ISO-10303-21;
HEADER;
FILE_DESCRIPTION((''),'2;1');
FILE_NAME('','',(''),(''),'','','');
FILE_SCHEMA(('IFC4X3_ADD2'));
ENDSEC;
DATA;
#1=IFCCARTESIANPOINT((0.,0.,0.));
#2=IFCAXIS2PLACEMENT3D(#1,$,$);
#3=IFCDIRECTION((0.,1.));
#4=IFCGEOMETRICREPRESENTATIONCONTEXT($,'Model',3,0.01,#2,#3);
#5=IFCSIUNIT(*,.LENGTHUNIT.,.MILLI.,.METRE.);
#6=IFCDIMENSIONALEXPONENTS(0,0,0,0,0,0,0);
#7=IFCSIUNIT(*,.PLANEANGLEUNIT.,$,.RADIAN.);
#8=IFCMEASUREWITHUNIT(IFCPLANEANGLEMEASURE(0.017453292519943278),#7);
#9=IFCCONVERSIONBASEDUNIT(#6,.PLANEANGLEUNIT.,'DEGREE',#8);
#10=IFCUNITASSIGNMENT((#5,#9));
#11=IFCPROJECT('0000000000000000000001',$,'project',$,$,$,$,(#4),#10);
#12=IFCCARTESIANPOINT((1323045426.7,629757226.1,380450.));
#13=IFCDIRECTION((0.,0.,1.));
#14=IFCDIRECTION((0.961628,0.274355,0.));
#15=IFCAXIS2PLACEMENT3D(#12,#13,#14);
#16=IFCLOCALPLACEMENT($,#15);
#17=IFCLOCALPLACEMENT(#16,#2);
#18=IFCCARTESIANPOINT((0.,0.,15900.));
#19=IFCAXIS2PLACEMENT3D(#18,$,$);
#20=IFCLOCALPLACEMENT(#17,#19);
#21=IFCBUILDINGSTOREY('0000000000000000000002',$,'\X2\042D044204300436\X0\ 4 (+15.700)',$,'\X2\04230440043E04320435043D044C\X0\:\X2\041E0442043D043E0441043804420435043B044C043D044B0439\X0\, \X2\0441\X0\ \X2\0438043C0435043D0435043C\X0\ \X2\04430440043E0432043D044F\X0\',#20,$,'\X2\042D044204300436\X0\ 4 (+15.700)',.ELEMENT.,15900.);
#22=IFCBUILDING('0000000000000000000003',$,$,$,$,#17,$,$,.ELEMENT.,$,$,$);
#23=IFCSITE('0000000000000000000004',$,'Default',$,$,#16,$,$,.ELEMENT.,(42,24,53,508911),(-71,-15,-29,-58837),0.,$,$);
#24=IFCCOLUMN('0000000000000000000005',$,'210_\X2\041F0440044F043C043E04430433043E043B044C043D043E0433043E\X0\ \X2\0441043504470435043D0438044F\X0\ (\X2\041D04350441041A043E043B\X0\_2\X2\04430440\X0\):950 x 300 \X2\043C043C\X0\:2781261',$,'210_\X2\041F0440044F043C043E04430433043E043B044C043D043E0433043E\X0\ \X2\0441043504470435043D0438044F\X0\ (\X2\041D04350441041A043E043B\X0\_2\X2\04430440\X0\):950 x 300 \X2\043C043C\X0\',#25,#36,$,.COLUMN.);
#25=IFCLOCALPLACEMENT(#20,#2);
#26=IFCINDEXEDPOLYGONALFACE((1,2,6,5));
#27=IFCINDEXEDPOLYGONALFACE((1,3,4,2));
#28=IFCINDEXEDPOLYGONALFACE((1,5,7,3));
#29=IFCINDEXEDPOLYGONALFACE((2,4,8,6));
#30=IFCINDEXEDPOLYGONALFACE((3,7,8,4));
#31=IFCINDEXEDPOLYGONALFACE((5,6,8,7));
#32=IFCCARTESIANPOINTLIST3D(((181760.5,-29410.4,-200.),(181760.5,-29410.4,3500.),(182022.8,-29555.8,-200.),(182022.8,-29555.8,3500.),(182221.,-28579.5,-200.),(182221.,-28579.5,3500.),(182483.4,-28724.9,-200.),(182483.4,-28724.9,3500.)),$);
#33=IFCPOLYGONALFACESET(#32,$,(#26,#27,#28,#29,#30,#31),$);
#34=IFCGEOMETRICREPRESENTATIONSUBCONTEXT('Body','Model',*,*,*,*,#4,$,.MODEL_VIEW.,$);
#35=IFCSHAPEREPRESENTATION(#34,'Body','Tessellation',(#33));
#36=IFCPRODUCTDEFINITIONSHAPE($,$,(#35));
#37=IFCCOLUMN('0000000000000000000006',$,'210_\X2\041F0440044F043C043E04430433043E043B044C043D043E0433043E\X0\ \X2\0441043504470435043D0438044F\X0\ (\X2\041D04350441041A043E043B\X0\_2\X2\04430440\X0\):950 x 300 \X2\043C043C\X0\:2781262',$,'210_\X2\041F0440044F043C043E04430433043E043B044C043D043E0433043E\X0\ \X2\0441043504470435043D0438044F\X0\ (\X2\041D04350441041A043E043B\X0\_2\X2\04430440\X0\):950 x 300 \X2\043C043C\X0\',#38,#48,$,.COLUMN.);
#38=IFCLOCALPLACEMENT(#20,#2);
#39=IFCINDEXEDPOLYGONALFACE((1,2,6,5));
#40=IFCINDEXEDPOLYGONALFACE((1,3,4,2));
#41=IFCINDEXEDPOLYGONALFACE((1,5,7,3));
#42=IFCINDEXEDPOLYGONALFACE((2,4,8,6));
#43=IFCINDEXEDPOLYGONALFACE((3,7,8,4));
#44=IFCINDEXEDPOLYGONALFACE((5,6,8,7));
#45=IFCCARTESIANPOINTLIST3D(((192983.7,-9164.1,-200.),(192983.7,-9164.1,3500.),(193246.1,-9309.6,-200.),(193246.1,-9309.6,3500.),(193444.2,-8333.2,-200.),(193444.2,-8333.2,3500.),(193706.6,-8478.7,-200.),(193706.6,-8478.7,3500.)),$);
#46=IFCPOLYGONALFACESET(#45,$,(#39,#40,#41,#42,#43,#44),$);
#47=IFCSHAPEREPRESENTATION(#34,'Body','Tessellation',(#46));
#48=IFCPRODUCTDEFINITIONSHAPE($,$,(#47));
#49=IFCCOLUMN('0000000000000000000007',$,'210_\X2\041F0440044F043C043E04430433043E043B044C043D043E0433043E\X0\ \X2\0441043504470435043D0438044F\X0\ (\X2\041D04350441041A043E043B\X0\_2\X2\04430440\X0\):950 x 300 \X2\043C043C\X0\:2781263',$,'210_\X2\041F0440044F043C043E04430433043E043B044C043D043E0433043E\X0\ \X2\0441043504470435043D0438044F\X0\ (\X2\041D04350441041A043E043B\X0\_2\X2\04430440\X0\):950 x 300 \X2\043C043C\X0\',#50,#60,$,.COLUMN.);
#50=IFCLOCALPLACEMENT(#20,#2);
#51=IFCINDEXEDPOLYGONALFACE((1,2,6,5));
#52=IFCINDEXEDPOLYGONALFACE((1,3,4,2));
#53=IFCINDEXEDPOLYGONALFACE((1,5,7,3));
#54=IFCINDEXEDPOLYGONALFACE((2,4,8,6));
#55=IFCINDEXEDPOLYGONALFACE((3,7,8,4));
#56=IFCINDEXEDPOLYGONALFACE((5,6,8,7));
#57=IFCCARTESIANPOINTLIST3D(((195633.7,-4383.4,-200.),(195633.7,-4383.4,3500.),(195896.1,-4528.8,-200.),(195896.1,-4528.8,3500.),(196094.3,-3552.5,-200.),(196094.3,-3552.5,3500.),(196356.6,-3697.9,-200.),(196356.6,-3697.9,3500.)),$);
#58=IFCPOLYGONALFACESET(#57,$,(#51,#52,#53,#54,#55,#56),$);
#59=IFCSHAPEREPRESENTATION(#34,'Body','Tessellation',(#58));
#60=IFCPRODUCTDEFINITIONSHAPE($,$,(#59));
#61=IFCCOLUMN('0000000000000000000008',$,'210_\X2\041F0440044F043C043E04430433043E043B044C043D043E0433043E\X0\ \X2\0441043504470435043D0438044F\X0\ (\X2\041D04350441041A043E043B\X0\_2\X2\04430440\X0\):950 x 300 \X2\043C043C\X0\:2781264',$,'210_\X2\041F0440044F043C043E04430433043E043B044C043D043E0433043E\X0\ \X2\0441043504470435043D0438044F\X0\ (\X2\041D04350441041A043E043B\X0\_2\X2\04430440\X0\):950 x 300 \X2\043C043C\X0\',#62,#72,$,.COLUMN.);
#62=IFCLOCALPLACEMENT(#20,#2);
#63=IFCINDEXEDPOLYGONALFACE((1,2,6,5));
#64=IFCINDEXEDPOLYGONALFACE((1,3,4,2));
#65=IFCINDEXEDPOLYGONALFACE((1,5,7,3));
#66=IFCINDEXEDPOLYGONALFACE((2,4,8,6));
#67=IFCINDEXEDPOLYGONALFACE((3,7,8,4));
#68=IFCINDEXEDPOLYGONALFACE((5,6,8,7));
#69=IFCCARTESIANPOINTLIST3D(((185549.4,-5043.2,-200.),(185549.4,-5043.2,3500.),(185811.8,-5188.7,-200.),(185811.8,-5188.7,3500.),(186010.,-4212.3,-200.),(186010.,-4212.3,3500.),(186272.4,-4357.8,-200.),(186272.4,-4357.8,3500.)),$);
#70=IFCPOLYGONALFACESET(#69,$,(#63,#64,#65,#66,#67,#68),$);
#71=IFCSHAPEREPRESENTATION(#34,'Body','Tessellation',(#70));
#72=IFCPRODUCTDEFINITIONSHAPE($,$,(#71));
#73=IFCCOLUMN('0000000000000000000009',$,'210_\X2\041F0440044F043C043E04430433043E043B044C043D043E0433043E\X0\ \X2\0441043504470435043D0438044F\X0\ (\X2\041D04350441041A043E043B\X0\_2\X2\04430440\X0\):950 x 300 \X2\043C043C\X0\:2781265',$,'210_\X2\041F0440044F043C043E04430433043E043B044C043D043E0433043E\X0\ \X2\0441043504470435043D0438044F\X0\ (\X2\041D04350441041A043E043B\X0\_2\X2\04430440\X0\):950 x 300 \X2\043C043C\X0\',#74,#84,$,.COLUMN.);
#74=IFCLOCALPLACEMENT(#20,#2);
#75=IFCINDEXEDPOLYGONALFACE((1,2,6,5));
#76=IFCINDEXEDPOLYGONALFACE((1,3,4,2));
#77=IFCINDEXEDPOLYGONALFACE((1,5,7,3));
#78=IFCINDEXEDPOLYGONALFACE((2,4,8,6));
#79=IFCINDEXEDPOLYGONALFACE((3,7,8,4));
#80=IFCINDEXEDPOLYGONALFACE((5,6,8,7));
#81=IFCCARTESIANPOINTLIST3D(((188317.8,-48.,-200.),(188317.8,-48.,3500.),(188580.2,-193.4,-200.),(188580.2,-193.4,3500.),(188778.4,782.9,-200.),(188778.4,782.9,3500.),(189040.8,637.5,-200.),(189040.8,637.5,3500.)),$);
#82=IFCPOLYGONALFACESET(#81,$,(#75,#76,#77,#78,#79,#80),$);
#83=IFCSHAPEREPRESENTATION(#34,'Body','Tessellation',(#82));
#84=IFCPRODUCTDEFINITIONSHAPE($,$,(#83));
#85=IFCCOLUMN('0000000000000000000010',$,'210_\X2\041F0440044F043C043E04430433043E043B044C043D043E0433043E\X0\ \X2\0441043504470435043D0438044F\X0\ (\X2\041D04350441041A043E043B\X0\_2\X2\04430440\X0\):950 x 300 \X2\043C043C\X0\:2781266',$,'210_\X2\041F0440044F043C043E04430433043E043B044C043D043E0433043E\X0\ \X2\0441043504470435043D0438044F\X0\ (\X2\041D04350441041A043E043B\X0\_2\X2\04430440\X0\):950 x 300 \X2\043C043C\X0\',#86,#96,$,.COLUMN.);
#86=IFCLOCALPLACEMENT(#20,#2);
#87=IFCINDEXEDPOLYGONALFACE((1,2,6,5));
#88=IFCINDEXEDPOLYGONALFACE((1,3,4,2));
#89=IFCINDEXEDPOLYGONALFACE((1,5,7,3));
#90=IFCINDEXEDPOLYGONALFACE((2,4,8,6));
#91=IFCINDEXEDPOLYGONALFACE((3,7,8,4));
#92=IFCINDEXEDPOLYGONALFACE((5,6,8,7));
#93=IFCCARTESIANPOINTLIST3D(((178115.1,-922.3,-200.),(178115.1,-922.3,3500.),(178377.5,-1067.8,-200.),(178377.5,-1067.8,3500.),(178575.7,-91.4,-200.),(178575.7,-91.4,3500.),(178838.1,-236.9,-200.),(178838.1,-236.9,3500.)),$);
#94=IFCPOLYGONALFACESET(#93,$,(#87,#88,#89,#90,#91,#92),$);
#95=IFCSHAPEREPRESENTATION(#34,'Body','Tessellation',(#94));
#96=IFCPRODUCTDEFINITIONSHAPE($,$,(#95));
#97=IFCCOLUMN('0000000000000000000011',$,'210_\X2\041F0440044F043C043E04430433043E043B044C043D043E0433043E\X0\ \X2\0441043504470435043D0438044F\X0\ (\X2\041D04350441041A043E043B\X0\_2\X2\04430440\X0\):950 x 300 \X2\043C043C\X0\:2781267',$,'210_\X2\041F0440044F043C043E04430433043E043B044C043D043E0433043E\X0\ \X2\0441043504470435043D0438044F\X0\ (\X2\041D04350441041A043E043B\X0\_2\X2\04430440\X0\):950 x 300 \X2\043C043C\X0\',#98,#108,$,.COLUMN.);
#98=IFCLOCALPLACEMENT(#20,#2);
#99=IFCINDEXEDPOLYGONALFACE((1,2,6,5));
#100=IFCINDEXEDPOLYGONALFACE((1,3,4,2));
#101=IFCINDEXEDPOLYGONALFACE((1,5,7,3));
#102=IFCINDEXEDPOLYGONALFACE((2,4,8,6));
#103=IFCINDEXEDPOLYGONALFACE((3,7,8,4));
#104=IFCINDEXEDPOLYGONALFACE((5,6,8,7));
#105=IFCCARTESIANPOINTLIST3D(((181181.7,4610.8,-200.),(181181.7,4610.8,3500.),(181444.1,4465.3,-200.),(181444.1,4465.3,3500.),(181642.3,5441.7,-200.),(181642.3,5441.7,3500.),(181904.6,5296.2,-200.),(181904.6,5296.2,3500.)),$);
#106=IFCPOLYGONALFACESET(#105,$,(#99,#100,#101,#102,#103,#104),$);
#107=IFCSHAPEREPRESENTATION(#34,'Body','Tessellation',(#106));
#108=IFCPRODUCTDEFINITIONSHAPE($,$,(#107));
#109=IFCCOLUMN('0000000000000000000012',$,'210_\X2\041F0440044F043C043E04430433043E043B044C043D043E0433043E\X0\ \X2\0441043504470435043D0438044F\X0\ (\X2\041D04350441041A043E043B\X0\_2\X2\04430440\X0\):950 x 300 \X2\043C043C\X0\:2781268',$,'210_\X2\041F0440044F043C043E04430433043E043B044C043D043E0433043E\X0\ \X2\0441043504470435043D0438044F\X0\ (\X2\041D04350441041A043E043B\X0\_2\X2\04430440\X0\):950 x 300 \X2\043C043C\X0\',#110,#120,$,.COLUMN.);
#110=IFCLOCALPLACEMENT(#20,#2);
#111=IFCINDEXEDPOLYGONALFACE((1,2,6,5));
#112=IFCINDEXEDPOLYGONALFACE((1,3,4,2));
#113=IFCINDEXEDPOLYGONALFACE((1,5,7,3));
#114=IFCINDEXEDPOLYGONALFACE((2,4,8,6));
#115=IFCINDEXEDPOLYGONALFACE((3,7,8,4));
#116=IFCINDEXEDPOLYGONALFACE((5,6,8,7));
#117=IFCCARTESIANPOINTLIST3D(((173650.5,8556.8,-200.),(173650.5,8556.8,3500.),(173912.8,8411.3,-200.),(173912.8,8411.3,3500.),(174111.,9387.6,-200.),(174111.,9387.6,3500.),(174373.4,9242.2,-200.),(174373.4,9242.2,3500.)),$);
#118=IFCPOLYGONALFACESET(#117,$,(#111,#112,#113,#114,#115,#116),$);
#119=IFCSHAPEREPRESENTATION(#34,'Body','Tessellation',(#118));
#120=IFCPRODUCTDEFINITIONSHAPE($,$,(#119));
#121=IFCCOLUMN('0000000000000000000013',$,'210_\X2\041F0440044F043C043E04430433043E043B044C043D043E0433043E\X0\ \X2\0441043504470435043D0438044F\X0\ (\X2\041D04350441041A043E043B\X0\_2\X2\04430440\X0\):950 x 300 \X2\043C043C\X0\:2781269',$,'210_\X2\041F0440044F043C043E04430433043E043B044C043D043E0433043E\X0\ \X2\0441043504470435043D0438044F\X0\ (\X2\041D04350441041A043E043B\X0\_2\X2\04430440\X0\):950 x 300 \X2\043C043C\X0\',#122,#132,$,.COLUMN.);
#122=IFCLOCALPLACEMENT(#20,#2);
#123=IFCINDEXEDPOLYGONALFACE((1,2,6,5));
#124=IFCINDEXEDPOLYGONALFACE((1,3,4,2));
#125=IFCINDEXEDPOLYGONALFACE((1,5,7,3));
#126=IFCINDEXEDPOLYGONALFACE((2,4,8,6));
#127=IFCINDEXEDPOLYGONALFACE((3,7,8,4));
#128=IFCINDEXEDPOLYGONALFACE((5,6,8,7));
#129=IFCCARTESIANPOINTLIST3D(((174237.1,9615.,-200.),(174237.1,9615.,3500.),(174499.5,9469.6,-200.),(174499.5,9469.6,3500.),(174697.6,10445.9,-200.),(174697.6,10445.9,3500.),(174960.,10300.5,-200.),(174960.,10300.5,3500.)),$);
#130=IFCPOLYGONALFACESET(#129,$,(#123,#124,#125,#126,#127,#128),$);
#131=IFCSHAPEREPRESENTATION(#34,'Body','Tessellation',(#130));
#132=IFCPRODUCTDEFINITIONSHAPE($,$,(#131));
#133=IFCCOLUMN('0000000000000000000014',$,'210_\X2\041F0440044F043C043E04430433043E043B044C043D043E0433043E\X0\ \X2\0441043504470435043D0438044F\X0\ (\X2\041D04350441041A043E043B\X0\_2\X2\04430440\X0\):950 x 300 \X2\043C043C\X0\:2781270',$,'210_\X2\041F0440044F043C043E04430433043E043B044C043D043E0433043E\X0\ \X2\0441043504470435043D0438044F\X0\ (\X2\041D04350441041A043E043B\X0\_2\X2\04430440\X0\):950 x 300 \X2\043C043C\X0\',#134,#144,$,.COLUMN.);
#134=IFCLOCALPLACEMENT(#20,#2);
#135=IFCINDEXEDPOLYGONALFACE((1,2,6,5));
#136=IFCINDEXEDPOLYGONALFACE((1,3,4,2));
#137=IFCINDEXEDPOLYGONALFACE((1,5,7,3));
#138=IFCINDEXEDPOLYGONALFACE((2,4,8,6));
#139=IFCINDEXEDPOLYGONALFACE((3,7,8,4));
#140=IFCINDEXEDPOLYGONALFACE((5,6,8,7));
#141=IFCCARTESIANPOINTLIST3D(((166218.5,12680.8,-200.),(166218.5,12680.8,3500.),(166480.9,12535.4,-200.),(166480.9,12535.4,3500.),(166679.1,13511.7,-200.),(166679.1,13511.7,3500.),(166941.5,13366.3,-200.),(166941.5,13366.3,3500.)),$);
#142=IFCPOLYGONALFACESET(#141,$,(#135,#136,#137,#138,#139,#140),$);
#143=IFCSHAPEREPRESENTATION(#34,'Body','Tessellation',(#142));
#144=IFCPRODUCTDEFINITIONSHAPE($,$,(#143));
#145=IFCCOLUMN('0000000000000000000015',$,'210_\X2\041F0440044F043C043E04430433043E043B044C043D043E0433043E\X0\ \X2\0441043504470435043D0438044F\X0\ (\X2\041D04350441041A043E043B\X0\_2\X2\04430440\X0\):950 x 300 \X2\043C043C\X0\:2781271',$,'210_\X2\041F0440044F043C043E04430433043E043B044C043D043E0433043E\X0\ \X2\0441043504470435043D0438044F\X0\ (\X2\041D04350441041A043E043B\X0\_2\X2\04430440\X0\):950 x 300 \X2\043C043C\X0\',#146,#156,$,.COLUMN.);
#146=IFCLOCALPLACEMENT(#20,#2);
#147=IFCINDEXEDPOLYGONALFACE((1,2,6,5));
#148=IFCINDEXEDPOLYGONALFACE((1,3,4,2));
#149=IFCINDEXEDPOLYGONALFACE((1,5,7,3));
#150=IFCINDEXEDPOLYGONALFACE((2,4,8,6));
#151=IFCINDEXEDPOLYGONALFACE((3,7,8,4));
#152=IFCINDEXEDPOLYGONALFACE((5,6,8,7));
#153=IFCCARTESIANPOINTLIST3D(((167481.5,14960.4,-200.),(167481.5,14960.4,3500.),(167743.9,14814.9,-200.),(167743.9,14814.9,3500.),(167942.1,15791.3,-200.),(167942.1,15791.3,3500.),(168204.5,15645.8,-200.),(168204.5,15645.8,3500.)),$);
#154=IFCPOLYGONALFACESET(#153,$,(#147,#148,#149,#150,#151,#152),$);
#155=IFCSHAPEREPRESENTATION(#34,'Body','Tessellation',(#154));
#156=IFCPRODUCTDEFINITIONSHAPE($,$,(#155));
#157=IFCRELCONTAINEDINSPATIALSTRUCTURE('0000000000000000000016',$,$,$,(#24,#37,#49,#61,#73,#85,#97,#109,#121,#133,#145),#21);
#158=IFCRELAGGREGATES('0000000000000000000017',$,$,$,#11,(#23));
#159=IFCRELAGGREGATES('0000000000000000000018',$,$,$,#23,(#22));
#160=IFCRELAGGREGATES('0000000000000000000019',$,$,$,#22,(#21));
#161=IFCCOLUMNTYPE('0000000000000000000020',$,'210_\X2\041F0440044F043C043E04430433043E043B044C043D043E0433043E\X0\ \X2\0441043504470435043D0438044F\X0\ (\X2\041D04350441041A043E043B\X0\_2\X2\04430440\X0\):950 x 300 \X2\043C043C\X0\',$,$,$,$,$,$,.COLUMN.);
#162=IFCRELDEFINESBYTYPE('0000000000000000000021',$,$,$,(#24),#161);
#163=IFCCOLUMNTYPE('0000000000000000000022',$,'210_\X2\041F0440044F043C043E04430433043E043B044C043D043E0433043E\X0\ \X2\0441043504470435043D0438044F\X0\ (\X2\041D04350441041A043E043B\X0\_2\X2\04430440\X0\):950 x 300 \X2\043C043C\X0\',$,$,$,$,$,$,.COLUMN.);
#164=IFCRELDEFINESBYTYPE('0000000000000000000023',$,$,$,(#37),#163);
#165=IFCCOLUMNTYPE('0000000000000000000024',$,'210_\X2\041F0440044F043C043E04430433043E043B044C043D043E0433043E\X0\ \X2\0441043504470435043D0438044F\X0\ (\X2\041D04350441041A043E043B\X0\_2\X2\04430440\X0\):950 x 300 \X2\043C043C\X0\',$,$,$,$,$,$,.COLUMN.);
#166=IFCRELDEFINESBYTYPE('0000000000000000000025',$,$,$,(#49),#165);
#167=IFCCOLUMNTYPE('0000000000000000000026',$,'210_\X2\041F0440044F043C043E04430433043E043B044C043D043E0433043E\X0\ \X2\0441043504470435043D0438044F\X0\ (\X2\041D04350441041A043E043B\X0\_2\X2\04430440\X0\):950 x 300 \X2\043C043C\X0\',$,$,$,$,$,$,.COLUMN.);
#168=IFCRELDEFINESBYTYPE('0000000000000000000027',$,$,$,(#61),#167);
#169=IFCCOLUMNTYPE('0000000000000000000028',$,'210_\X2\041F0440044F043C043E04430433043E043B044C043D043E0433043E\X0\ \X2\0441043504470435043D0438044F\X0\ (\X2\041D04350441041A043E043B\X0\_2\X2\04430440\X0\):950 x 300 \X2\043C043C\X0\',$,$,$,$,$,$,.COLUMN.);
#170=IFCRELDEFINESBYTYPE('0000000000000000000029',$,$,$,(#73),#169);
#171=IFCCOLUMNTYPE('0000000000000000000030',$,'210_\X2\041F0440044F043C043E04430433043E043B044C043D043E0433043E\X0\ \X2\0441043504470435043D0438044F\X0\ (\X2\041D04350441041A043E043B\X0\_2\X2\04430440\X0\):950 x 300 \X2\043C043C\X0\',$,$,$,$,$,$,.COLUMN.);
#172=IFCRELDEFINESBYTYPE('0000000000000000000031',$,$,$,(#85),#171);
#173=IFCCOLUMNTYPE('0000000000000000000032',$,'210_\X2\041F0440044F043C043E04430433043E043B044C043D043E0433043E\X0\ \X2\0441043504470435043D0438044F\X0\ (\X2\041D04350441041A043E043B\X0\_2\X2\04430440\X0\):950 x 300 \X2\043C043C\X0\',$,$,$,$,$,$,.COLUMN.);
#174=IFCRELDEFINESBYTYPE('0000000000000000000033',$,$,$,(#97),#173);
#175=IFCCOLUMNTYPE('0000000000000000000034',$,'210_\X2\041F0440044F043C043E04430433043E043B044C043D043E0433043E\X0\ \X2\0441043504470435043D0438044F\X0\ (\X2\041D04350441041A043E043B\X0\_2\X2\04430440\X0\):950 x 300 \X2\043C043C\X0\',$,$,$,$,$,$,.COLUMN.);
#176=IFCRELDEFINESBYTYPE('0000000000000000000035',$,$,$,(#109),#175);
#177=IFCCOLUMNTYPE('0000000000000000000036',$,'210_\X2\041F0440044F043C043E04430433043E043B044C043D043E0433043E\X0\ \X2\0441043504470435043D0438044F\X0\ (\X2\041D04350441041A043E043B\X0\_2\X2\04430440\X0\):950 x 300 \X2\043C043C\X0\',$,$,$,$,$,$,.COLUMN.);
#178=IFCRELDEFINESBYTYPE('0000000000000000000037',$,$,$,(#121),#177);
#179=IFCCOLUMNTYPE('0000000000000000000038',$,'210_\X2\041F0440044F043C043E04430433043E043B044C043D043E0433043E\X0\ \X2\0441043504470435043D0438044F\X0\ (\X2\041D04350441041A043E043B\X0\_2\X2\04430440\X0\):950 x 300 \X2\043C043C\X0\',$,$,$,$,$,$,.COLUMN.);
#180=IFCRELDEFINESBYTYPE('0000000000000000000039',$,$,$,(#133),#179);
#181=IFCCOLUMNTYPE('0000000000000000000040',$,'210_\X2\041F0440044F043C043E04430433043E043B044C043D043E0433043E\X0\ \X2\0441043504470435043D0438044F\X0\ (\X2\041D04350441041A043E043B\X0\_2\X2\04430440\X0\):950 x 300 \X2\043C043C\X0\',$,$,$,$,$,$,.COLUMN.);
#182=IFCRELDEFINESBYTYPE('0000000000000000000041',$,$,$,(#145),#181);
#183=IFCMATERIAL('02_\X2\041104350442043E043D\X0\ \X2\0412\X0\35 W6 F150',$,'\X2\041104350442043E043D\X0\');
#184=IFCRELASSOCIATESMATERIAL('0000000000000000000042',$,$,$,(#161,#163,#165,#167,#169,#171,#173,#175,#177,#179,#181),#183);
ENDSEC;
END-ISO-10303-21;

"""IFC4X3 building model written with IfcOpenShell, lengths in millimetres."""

from ifc_helpers import new_model, entity, si_unit, converted_unit, direction, frame, frame_2d, origin, origin_2d_with_axis, place, context, subcontext, project, spatial, rectangle, extrude, source, transform, mapped, material, material_profile, profile_set, type_object, type_shapes, element, save


model = new_model("IFC4X3")

# Units and contexts
model_context = context("Model", 3, precision=0.01, world=origin(), true_north=direction((0.0, 1.0)))
body_context = subcontext(model_context, "Body", "Model", "MODEL_VIEW")
ifc_project = project(units=[si_unit("LENGTHUNIT", "METRE", prefix="MILLI"), converted_unit("PLANEANGLEUNIT", "DEGREE", entity("IfcPlaneAngleMeasure", 0.017453292519943278), si_unit("PLANEANGLEUNIT", "RADIAN"), dimensions=[0, 0, 0, 0, 0, 0, 0])], contexts=[model_context])

# Site, building, storey
site_placement = place(None, frame((1323045426.7, 629757226.1, 380450.0), z_axis=(0.0, 0.0, 1.0), x_axis=(0.961628, 0.274355, 0.0)))
site = spatial("IfcSite", under=ifc_project, at=site_placement, Name="Default", CompositionType="ELEMENT", RefLatitude=(42, 24, 53, 508911), RefLongitude=(-71, -15, -29, -58837), RefElevation=0.0)
building_placement = place(site_placement, origin())
building = spatial("IfcBuilding", under=site, at=building_placement, CompositionType="ELEMENT")
storey_placement = place(building_placement, frame((0.0, 0.0, 15900.0)))
storey = spatial("IfcBuildingStorey", under=building, at=storey_placement, Name="Этаж 4 (+15.700)", ObjectType="Уровень:Относительный, с именем уровня", LongName="Этаж 4 (+15.700)", CompositionType="ELEMENT", Elevation=15900.0)

# Columns
ifc_material = material(Name="02_Бетон В35 W6 F150", Category="Бетон")
ifc_material_profile_1 = material_profile(ifc_material, rectangle(XDim=300.0, YDim=950.0, at=frame_2d((0.0, 0.0), x_axis=(1.0, 0.0))), Name="950 x 300 мм")
ifc_profile_set_1 = profile_set([ifc_material_profile_1], Name="950 x 300 мм")
column_type_1 = type_object("IfcColumnType", Name="210_Прямоугольного сечения (НесКол_2ур):950 x 300 мм", PredefinedType="COLUMN", material=ifc_profile_set_1)
shared_shape_1 = source(origin(), body_context, "Body", "SweptSolid", [
    extrude(rectangle(XDim=300.0, YDim=950.0, at=origin_2d_with_axis()), frame((182121.9, -29067.7, 15700.0), z_axis=(0.0, 0.0, 1.0), x_axis=(-0.87462, 0.48481, 0.0)), (0.0, 0.0, 1.0), 3700.0),
])
type_shapes(column_type_1, [shared_shape_1])
column_1_placement = place(storey_placement, frame((0.0, 0.0, -15900.0)))
element("IfcColumn", 1, at=column_1_placement, inside=storey, type_object=column_type_1, Name="210_Прямоугольного сечения (НесКол_2ур):950 x 300 мм:2781261", ObjectType="210_Прямоугольного сечения (НесКол_2ур):950 x 300 мм", PredefinedType="COLUMN", context=body_context, shape_type="MappedRepresentation", body=[
    mapped(shared_shape_1, transform((0.0, 0.0, 0.0), scale=1.0)),
])
column_type_2 = type_object("IfcColumnType", Name="210_Прямоугольного сечения (НесКол_2ур):950 x 300 мм", PredefinedType="COLUMN", material=ifc_profile_set_1)
shared_shape_2 = source(origin(), body_context, "Body", "SweptSolid", [
    extrude(rectangle(XDim=300.0, YDim=950.0, at=frame_2d((0.0, 0.0), x_axis=(1.0, 0.0))), frame((193345.2, -8821.4, 15700.0), z_axis=(0.0, 0.0, 1.0), x_axis=(-0.87462, 0.48481, 0.0)), (0.0, 0.0, 1.0), 3700.0),
])
type_shapes(column_type_2, [shared_shape_2])
column_2_placement = place(storey_placement, frame((0.0, 0.0, -15900.0)))
element("IfcColumn", 2, at=column_2_placement, inside=storey, type_object=column_type_2, Name="210_Прямоугольного сечения (НесКол_2ур):950 x 300 мм:2781262", ObjectType="210_Прямоугольного сечения (НесКол_2ур):950 x 300 мм", PredefinedType="COLUMN", context=body_context, shape_type="MappedRepresentation", body=[
    mapped(shared_shape_2, transform((0.0, 0.0, 0.0), scale=1.0)),
])
column_type_3 = type_object("IfcColumnType", Name="210_Прямоугольного сечения (НесКол_2ур):950 x 300 мм", PredefinedType="COLUMN", material=ifc_profile_set_1)
shared_shape_3 = source(origin(), body_context, "Body", "SweptSolid", [
    extrude(rectangle(XDim=300.0, YDim=950.0, at=frame_2d((0.0, 0.0), x_axis=(1.0, 0.0))), frame((195995.2, -4040.7, 15700.0), z_axis=(0.0, 0.0, 1.0), x_axis=(-0.87462, 0.48481, 0.0)), (0.0, 0.0, 1.0), 3700.0),
])
type_shapes(column_type_3, [shared_shape_3])
column_3_placement = place(storey_placement, frame((0.0, 0.0, -15900.0)))
element("IfcColumn", 3, at=column_3_placement, inside=storey, type_object=column_type_3, Name="210_Прямоугольного сечения (НесКол_2ур):950 x 300 мм:2781263", ObjectType="210_Прямоугольного сечения (НесКол_2ур):950 x 300 мм", PredefinedType="COLUMN", context=body_context, shape_type="MappedRepresentation", body=[
    mapped(shared_shape_3, transform((0.0, 0.0, 0.0), scale=1.0)),
])
column_type_4 = type_object("IfcColumnType", Name="210_Прямоугольного сечения (НесКол_2ур):950 x 300 мм", PredefinedType="COLUMN", material=ifc_profile_set_1)
shared_shape_4 = source(origin(), body_context, "Body", "SweptSolid", [
    extrude(rectangle(XDim=300.0, YDim=950.0, at=frame_2d((0.0, 0.0), x_axis=(1.0, 0.0))), frame((185910.9, -4700.5, 15700.0), z_axis=(0.0, 0.0, 1.0), x_axis=(-0.87462, 0.48481, 0.0)), (0.0, 0.0, 1.0), 3700.0),
])
type_shapes(column_type_4, [shared_shape_4])
column_4_placement = place(storey_placement, frame((0.0, 0.0, -15900.0)))
element("IfcColumn", 4, at=column_4_placement, inside=storey, type_object=column_type_4, Name="210_Прямоугольного сечения (НесКол_2ур):950 x 300 мм:2781264", ObjectType="210_Прямоугольного сечения (НесКол_2ур):950 x 300 мм", PredefinedType="COLUMN", context=body_context, shape_type="MappedRepresentation", body=[
    mapped(shared_shape_4, transform((0.0, 0.0, 0.0), scale=1.0)),
])
column_type_5 = type_object("IfcColumnType", Name="210_Прямоугольного сечения (НесКол_2ур):950 x 300 мм", PredefinedType="COLUMN", material=ifc_profile_set_1)
shared_shape_5 = source(origin(), body_context, "Body", "SweptSolid", [
    extrude(rectangle(XDim=300.0, YDim=950.0, at=frame_2d((0.0, 0.0), x_axis=(1.0, 0.0))), frame((188679.3, 294.7, 15700.0), z_axis=(0.0, 0.0, 1.0), x_axis=(-0.87462, 0.48481, 0.0)), (0.0, 0.0, 1.0), 3700.0),
])
type_shapes(column_type_5, [shared_shape_5])
column_5_placement = place(storey_placement, frame((0.0, 0.0, -15900.0)))
element("IfcColumn", 5, at=column_5_placement, inside=storey, type_object=column_type_5, Name="210_Прямоугольного сечения (НесКол_2ур):950 x 300 мм:2781265", ObjectType="210_Прямоугольного сечения (НесКол_2ур):950 x 300 мм", PredefinedType="COLUMN", context=body_context, shape_type="MappedRepresentation", body=[
    mapped(shared_shape_5, transform((0.0, 0.0, 0.0), scale=1.0)),
])
column_type_6 = type_object("IfcColumnType", Name="210_Прямоугольного сечения (НесКол_2ур):950 x 300 мм", PredefinedType="COLUMN", material=ifc_profile_set_1)
shared_shape_6 = source(origin(), body_context, "Body", "SweptSolid", [
    extrude(rectangle(XDim=300.0, YDim=950.0, at=frame_2d((0.0, 0.0), x_axis=(1.0, 0.0))), frame((178476.6, -579.6, 15700.0), z_axis=(0.0, 0.0, 1.0), x_axis=(-0.87462, 0.48481, 0.0)), (0.0, 0.0, 1.0), 3700.0),
])
type_shapes(column_type_6, [shared_shape_6])
column_6_placement = place(storey_placement, frame((0.0, 0.0, -15900.0)))
element("IfcColumn", 6, at=column_6_placement, inside=storey, type_object=column_type_6, Name="210_Прямоугольного сечения (НесКол_2ур):950 x 300 мм:2781266", ObjectType="210_Прямоугольного сечения (НесКол_2ур):950 x 300 мм", PredefinedType="COLUMN", context=body_context, shape_type="MappedRepresentation", body=[
    mapped(shared_shape_6, transform((0.0, 0.0, 0.0), scale=1.0)),
])
column_type_7 = type_object("IfcColumnType", Name="210_Прямоугольного сечения (НесКол_2ур):950 x 300 мм", PredefinedType="COLUMN", material=ifc_profile_set_1)
shared_shape_7 = source(origin(), body_context, "Body", "SweptSolid", [
    extrude(rectangle(XDim=300.0, YDim=950.0, at=frame_2d((0.0, 0.0), x_axis=(1.0, 0.0))), frame((181543.2, 4953.5, 15700.0), z_axis=(0.0, 0.0, 1.0), x_axis=(-0.87462, 0.48481, 0.0)), (0.0, 0.0, 1.0), 3700.0),
])
type_shapes(column_type_7, [shared_shape_7])
column_7_placement = place(storey_placement, frame((0.0, 0.0, -15900.0)))
element("IfcColumn", 7, at=column_7_placement, inside=storey, type_object=column_type_7, Name="210_Прямоугольного сечения (НесКол_2ур):950 x 300 мм:2781267", ObjectType="210_Прямоугольного сечения (НесКол_2ур):950 x 300 мм", PredefinedType="COLUMN", context=body_context, shape_type="MappedRepresentation", body=[
    mapped(shared_shape_7, transform((0.0, 0.0, 0.0), scale=1.0)),
])
column_type_8 = type_object("IfcColumnType", Name="210_Прямоугольного сечения (НесКол_2ур):950 x 300 мм", PredefinedType="COLUMN", material=ifc_profile_set_1)
shared_shape_8 = source(origin(), body_context, "Body", "SweptSolid", [
    extrude(rectangle(XDim=300.0, YDim=950.0, at=frame_2d((0.0, 0.0), x_axis=(1.0, 0.0))), frame((174011.9, 8899.5, 15700.0), z_axis=(0.0, 0.0, 1.0), x_axis=(-0.87462, 0.48481, 0.0)), (0.0, 0.0, 1.0), 3700.0),
])
type_shapes(column_type_8, [shared_shape_8])
column_8_placement = place(storey_placement, frame((0.0, 0.0, -15900.0)))
element("IfcColumn", 8, at=column_8_placement, inside=storey, type_object=column_type_8, Name="210_Прямоугольного сечения (НесКол_2ур):950 x 300 мм:2781268", ObjectType="210_Прямоугольного сечения (НесКол_2ур):950 x 300 мм", PredefinedType="COLUMN", context=body_context, shape_type="MappedRepresentation", body=[
    mapped(shared_shape_8, transform((0.0, 0.0, 0.0), scale=1.0)),
])
column_type_9 = type_object("IfcColumnType", Name="210_Прямоугольного сечения (НесКол_2ур):950 x 300 мм", PredefinedType="COLUMN", material=ifc_profile_set_1)
shared_shape_9 = source(origin(), body_context, "Body", "SweptSolid", [
    extrude(rectangle(XDim=300.0, YDim=950.0, at=frame_2d((0.0, 0.0), x_axis=(1.0, 0.0))), frame((174598.6, 9957.8, 15700.0), z_axis=(0.0, 0.0, 1.0), x_axis=(-0.87462, 0.48481, 0.0)), (0.0, 0.0, 1.0), 3700.0),
])
type_shapes(column_type_9, [shared_shape_9])
column_9_placement = place(storey_placement, frame((0.0, 0.0, -15900.0)))
element("IfcColumn", 9, at=column_9_placement, inside=storey, type_object=column_type_9, Name="210_Прямоугольного сечения (НесКол_2ур):950 x 300 мм:2781269", ObjectType="210_Прямоугольного сечения (НесКол_2ур):950 x 300 мм", PredefinedType="COLUMN", context=body_context, shape_type="MappedRepresentation", body=[
    mapped(shared_shape_9, transform((0.0, 0.0, 0.0), scale=1.0)),
])
column_type_10 = type_object("IfcColumnType", Name="210_Прямоугольного сечения (НесКол_2ур):950 x 300 мм", PredefinedType="COLUMN", material=ifc_profile_set_1)
shared_shape_10 = source(origin(), body_context, "Body", "SweptSolid", [
    extrude(rectangle(XDim=300.0, YDim=950.0, at=frame_2d((0.0, 0.0), x_axis=(1.0, 0.0))), frame((166580.0, 13023.6, 15700.0), z_axis=(0.0, 0.0, 1.0), x_axis=(-0.87462, 0.48481, 0.0)), (0.0, 0.0, 1.0), 3700.0),
])
type_shapes(column_type_10, [shared_shape_10])
column_10_placement = place(storey_placement, frame((0.0, 0.0, -15900.0)))
element("IfcColumn", 10, at=column_10_placement, inside=storey, type_object=column_type_10, Name="210_Прямоугольного сечения (НесКол_2ур):950 x 300 мм:2781270", ObjectType="210_Прямоугольного сечения (НесКол_2ур):950 x 300 мм", PredefinedType="COLUMN", context=body_context, shape_type="MappedRepresentation", body=[
    mapped(shared_shape_10, transform((0.0, 0.0, 0.0), scale=1.0)),
])
column_type_11 = type_object("IfcColumnType", Name="210_Прямоугольного сечения (НесКол_2ур):950 x 300 мм", PredefinedType="COLUMN", material=ifc_profile_set_1)
shared_shape_11 = source(origin(), body_context, "Body", "SweptSolid", [
    extrude(rectangle(XDim=300.0, YDim=950.0, at=frame_2d((0.0, 0.0), x_axis=(1.0, 0.0))), frame((167843.0, 15303.1, 15700.0), z_axis=(0.0, 0.0, 1.0), x_axis=(-0.87462, 0.48481, 0.0)), (0.0, 0.0, 1.0), 3700.0),
])
type_shapes(column_type_11, [shared_shape_11])
column_11_placement = place(storey_placement, frame((0.0, 0.0, -15900.0)))
element("IfcColumn", 11, at=column_11_placement, inside=storey, type_object=column_type_11, Name="210_Прямоугольного сечения (НесКол_2ур):950 x 300 мм:2781271", ObjectType="210_Прямоугольного сечения (НесКол_2ур):950 x 300 мм", PredefinedType="COLUMN", context=body_context, shape_type="MappedRepresentation", body=[
    mapped(shared_shape_11, transform((0.0, 0.0, 0.0), scale=1.0)),
])

save(model, "model.ifc")
